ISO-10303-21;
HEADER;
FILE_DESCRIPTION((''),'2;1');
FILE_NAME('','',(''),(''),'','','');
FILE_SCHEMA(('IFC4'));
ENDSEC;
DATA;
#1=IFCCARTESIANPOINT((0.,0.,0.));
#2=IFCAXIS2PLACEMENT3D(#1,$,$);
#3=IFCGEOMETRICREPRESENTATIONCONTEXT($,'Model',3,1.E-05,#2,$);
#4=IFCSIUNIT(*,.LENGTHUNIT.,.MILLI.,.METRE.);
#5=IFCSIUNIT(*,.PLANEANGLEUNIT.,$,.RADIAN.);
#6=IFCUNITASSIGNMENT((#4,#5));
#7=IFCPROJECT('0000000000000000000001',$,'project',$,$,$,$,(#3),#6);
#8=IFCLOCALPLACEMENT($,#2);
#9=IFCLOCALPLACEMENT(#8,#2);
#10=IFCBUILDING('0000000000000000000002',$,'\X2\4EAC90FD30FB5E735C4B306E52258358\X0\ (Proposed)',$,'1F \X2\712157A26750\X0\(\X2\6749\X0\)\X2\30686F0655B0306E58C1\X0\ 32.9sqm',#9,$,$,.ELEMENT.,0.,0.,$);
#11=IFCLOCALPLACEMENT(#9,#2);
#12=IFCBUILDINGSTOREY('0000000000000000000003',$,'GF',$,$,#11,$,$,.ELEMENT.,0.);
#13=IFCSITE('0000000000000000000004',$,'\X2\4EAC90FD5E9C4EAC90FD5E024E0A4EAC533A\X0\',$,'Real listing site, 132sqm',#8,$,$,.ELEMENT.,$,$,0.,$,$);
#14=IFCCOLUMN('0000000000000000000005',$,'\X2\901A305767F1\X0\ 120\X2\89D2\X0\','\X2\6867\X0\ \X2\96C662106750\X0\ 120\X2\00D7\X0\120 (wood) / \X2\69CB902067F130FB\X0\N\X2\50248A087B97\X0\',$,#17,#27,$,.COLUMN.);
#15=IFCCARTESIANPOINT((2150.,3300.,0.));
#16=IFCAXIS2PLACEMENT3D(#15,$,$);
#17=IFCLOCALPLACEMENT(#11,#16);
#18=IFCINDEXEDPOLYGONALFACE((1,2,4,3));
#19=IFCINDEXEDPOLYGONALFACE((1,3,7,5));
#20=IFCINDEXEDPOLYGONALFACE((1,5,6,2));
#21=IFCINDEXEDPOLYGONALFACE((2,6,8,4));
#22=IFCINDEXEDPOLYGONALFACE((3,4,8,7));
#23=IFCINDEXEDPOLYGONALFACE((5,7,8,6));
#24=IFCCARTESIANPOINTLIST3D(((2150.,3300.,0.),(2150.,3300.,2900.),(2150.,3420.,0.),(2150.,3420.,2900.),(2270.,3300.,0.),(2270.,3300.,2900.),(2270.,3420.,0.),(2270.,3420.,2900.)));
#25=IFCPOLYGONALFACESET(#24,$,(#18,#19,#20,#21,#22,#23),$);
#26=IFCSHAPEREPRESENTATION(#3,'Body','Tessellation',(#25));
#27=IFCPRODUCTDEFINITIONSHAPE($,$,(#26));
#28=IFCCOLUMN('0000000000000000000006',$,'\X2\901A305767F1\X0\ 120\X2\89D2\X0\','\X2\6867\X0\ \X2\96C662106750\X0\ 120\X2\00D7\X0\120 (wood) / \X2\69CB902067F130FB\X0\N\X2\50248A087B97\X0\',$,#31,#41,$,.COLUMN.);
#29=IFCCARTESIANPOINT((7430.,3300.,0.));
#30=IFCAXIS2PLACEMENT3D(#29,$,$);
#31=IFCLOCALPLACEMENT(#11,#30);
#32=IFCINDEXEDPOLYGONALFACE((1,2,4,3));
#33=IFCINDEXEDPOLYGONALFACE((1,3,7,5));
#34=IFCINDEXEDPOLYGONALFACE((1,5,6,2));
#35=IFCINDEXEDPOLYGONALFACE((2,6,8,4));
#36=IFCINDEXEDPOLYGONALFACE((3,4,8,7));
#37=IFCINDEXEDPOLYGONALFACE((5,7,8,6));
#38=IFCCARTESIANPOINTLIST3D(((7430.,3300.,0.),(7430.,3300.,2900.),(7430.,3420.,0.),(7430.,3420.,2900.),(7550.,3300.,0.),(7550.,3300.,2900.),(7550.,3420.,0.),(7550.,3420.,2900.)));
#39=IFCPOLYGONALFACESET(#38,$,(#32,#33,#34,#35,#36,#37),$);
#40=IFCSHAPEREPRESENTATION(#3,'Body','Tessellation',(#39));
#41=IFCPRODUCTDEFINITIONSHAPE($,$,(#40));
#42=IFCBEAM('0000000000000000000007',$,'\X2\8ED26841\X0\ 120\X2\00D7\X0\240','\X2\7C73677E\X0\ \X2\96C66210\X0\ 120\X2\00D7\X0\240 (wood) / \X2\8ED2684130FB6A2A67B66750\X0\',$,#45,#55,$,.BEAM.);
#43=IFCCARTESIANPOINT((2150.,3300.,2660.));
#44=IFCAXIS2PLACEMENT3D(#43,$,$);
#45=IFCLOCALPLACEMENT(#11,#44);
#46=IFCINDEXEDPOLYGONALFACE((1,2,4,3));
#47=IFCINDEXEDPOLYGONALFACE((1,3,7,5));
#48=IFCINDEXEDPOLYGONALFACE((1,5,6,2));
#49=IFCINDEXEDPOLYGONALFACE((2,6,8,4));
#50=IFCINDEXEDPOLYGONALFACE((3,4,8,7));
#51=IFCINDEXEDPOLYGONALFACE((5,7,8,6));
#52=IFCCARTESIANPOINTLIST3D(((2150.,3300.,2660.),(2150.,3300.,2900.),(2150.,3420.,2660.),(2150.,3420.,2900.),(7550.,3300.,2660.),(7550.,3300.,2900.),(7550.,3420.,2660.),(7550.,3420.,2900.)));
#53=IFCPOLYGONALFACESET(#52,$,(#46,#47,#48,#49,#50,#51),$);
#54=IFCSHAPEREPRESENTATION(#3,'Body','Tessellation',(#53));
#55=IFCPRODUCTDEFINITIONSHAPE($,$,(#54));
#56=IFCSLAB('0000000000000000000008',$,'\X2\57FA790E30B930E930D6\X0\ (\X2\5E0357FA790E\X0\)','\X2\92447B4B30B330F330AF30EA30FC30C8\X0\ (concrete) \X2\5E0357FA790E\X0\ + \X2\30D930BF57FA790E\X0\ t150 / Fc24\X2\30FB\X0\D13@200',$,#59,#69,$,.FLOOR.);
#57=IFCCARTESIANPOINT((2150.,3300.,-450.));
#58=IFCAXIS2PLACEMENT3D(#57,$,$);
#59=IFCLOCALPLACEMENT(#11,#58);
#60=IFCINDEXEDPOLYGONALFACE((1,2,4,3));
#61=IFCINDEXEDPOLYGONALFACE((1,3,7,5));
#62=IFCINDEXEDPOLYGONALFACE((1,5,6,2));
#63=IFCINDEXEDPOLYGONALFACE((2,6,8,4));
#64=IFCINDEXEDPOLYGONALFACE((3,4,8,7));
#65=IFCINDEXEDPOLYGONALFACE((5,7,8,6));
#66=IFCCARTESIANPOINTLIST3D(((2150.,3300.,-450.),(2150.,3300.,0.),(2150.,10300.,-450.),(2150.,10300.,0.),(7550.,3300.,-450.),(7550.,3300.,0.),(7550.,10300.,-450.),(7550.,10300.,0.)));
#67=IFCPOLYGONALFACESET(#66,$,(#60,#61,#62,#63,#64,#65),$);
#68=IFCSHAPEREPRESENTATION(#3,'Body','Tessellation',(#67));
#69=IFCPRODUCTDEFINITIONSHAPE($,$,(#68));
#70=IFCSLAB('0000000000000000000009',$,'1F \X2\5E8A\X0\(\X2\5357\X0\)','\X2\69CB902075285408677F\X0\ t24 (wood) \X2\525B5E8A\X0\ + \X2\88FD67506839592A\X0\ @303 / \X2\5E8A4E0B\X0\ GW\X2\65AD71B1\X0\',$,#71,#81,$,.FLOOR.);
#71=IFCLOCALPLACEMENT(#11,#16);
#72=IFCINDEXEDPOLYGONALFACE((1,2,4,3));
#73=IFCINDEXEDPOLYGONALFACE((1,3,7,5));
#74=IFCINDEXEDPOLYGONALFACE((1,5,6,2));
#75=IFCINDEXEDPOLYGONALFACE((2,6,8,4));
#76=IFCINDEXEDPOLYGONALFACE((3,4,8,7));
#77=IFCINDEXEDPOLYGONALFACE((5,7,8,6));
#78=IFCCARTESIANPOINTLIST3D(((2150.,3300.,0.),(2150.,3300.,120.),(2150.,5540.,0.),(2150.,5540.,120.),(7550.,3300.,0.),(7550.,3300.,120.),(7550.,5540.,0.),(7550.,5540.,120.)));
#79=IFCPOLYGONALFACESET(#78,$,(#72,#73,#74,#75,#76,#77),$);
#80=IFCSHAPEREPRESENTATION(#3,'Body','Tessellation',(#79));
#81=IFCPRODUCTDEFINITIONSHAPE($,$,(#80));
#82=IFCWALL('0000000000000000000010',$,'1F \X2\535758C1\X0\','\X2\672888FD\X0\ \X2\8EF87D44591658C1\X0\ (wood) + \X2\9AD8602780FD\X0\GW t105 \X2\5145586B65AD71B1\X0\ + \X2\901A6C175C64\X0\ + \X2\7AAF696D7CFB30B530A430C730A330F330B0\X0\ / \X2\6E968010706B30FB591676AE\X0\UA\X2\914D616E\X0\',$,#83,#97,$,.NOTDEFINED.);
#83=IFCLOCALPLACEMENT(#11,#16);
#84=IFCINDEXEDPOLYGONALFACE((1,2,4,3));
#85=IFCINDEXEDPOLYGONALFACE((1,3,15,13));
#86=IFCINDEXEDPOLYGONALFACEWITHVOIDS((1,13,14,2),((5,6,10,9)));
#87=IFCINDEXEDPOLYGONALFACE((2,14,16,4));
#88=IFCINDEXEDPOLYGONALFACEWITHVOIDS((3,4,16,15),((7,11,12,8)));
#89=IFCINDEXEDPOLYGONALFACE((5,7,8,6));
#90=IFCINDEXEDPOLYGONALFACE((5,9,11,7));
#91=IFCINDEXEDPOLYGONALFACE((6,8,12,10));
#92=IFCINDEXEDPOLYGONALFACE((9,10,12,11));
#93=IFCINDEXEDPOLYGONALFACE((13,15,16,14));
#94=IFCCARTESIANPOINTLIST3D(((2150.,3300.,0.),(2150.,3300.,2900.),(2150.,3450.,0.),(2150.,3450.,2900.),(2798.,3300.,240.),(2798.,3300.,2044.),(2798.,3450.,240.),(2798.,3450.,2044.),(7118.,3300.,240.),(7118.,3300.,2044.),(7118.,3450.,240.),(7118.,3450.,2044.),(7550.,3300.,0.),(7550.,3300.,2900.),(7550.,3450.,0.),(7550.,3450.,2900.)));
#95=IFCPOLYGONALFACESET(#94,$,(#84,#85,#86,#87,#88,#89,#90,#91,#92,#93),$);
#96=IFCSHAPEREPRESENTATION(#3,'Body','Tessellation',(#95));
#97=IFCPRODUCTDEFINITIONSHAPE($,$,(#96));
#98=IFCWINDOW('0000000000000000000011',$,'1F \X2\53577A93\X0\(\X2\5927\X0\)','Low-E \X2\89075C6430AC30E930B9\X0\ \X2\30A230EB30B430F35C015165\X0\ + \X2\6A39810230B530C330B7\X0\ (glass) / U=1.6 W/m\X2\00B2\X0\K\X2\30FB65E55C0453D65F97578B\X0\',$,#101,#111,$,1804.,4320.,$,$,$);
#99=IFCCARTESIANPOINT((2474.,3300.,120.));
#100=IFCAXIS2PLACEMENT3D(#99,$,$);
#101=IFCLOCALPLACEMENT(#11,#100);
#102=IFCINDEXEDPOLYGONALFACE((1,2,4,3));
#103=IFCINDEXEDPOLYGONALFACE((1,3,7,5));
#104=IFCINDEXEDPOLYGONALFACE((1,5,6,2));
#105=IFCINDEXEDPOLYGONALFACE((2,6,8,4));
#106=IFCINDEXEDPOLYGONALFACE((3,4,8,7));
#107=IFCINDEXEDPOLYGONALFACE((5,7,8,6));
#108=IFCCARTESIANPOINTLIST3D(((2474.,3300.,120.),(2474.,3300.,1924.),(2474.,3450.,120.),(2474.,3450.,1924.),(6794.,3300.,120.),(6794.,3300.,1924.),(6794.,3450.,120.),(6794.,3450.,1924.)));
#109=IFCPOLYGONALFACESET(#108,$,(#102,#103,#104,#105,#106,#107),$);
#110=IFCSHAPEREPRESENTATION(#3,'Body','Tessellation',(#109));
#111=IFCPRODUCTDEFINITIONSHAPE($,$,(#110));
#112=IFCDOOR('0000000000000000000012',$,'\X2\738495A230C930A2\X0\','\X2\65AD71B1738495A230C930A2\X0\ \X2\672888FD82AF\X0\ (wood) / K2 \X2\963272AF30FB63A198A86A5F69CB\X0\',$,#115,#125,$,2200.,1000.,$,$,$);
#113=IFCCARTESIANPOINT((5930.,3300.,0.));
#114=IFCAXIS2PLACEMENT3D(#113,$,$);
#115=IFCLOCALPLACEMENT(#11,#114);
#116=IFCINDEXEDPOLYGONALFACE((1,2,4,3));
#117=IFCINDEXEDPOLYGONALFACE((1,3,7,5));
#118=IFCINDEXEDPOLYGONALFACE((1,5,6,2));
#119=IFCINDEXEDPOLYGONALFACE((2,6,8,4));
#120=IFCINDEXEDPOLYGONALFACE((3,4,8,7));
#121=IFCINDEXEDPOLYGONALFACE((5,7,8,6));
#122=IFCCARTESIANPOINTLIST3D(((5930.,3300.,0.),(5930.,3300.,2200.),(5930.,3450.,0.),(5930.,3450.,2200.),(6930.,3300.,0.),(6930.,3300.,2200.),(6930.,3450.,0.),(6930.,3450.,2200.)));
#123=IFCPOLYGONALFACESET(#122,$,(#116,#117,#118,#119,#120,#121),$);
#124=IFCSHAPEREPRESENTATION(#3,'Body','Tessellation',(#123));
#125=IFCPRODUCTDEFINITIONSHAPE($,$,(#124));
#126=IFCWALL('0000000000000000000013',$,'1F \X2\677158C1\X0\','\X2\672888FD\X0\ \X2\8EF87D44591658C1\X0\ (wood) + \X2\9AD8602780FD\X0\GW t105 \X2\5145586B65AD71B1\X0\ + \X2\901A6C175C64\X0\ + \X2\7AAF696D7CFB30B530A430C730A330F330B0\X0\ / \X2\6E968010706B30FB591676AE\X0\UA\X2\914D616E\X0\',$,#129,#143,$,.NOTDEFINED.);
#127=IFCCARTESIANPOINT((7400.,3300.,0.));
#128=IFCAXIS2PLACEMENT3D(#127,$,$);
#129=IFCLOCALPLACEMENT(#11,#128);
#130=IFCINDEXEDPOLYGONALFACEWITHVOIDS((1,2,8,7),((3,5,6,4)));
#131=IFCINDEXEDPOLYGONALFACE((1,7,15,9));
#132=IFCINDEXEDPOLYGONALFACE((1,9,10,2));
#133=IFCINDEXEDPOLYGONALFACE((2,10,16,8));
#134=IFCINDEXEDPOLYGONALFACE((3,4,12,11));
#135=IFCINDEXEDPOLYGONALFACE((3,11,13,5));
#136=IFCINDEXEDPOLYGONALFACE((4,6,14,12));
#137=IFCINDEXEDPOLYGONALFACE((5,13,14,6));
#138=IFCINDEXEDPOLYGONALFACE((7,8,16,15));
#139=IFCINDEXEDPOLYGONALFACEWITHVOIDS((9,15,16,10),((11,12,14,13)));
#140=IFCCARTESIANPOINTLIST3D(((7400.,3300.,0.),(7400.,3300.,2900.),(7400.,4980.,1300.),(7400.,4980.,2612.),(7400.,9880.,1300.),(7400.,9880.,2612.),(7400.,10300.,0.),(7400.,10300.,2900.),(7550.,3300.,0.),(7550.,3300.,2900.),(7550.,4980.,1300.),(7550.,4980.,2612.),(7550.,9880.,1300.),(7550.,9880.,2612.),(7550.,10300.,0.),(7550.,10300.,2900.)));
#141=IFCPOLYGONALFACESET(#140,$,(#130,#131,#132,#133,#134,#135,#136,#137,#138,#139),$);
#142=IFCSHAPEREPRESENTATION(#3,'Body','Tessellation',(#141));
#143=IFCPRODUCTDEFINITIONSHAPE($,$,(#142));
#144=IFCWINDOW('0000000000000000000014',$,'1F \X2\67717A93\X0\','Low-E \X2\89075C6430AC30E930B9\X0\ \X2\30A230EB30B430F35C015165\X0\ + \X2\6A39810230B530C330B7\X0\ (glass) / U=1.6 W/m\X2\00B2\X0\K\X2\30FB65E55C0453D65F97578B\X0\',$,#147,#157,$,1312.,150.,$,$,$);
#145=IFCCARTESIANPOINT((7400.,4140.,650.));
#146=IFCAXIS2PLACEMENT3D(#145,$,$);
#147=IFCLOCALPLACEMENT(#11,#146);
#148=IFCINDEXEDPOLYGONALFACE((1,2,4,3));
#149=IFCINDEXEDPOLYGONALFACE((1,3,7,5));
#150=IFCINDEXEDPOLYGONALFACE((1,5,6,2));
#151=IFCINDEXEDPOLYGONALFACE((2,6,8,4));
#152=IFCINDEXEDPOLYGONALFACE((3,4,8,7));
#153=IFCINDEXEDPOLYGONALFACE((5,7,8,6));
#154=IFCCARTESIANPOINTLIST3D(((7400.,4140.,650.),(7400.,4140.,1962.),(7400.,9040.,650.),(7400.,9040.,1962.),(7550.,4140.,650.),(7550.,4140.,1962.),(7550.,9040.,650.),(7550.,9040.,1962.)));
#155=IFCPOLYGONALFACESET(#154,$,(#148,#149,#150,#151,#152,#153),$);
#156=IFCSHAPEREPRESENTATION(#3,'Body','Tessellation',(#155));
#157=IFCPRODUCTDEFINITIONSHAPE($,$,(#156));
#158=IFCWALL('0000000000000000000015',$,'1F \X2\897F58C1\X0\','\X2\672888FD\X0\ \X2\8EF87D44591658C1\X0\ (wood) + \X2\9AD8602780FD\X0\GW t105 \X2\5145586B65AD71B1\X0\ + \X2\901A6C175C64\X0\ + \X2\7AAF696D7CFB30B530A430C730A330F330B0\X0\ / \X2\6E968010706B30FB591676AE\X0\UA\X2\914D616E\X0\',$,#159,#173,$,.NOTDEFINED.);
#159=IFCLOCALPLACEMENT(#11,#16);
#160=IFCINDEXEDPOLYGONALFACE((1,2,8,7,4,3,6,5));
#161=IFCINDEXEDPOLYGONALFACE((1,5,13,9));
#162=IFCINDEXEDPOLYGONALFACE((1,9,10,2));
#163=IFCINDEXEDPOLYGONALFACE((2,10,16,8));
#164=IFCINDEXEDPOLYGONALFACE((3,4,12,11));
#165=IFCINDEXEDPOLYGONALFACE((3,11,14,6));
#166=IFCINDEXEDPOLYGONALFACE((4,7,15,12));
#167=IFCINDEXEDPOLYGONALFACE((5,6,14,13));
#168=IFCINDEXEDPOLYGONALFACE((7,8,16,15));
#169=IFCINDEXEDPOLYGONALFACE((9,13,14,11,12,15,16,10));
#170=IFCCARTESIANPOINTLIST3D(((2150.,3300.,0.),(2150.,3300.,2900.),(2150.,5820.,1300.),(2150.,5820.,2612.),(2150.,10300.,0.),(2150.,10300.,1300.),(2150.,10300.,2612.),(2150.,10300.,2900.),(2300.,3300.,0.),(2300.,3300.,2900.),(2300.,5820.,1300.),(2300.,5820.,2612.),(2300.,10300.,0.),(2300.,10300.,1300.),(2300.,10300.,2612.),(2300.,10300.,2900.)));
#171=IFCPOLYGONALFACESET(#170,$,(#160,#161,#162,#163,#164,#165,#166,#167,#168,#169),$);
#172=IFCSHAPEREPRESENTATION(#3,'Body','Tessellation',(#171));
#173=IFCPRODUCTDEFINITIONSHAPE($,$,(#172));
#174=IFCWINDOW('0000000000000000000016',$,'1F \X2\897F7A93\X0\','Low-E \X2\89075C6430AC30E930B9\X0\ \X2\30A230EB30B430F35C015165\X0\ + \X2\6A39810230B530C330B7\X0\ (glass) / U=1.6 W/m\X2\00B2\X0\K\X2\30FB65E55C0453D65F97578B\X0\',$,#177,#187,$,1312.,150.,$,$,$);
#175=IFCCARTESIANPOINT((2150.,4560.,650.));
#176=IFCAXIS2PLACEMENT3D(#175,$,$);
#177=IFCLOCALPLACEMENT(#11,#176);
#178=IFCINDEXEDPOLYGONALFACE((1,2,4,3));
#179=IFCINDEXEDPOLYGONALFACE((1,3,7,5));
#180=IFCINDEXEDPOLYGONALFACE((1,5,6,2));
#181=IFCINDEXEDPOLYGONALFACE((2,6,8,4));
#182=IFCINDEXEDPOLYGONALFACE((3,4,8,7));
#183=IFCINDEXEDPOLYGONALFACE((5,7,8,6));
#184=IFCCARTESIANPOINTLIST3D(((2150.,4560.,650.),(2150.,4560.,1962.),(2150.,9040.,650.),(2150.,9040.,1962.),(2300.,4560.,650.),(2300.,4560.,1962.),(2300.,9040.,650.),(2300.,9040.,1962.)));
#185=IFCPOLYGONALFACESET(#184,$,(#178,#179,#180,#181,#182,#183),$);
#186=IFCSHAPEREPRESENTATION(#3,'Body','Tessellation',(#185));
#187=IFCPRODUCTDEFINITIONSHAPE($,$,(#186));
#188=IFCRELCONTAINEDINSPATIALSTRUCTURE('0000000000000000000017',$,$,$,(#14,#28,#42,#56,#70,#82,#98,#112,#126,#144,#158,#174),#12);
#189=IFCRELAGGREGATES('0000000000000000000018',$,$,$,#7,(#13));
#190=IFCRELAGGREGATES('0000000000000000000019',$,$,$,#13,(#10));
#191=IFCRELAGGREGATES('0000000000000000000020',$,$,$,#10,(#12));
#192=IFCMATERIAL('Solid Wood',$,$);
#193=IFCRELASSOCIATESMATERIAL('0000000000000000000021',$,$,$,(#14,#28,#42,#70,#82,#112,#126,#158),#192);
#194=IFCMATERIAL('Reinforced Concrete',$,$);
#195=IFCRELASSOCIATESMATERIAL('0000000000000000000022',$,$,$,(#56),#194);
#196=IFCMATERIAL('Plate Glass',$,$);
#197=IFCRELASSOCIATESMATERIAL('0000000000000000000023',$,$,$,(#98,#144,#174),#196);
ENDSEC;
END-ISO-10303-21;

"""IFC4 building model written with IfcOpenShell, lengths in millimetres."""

from ifc_helpers import new_model, si_unit, frame, frame_2d, origin, place, context, project, spatial, rectangle, extrude, material, element, fill, save


model = new_model("IFC4")

# Units and contexts
model_context = context("Model", 3, precision=1e-05, world=origin())
ifc_project = project(units=[si_unit("LENGTHUNIT", "METRE", prefix="MILLI"), si_unit("PLANEANGLEUNIT", "RADIAN")], contexts=[model_context])

# Site, building, storey
site_placement = place(None, origin())
site = spatial("IfcSite", under=ifc_project, at=site_placement, Name="京都府京都市上京区", ObjectType="Real listing site, 132sqm", CompositionType="ELEMENT", RefElevation=0.0)
building_placement = place(site_placement, origin())
building = spatial("IfcBuilding", under=site, at=building_placement, Name="京都・平屋の別荘 (Proposed)", ObjectType="1F 無垢材(杉)と漆喰の壁 32.9sqm", CompositionType="ELEMENT", ElevationOfRefHeight=0.0, ElevationOfTerrain=0.0)
storey_placement = place(building_placement, origin())
storey = spatial("IfcBuildingStorey", under=building, at=storey_placement, Name="GF", CompositionType="ELEMENT", Elevation=0.0)

# Columns
ifc_material_1 = material(Name="Solid Wood")
column_1_placement = place(storey_placement, frame((2150.0, 3300.0, 0.0)))
element("IfcColumn", 1, at=column_1_placement, inside=storey, material=ifc_material_1, Name="通し柱 120角", Description="桧 集成材 120×120 (wood) / 構造柱・N値計算", PredefinedType="COLUMN", context=model_context, shape_type="SweptSolid", body=[
    extrude(rectangle(XDim=120.0, YDim=120.0, at=frame_2d((60.0, 60.0))), frame((2150.0, 3300.0, 0.0)), (0.0, 0.0, 1.0), 2900.0),
])
column_2_placement = place(storey_placement, frame((7430.0, 3300.0, 0.0)))
element("IfcColumn", 2, at=column_2_placement, inside=storey, material=ifc_material_1, Name="通し柱 120角", Description="桧 集成材 120×120 (wood) / 構造柱・N値計算", PredefinedType="COLUMN", context=model_context, shape_type="SweptSolid", body=[
    extrude(rectangle(XDim=120.0, YDim=120.0, at=frame_2d((60.0, 60.0))), frame((7430.0, 3300.0, 0.0)), (0.0, 0.0, 1.0), 2900.0),
])

# Beam
beam_1_placement = place(storey_placement, frame((2150.0, 3300.0, 2660.0)))
element("IfcBeam", 3, at=beam_1_placement, inside=storey, material=ifc_material_1, Name="軒桁 120×240", Description="米松 集成 120×240 (wood) / 軒桁・横架材", PredefinedType="BEAM", context=model_context, shape_type="SweptSolid", body=[
    extrude(rectangle(XDim=5400.0, YDim=120.0, at=frame_2d((2700.0, 60.0))), frame((2150.0, 3300.0, 2660.0)), (0.0, 0.0, 1.0), 240.0),
])

# Slabs
ifc_material_2 = material(Name="Reinforced Concrete")
slab_1_placement = place(storey_placement, frame((2150.0, 3300.0, -450.0)))
element("IfcSlab", 4, at=slab_1_placement, inside=storey, material=ifc_material_2, Name="基礎スラブ (布基礎)", Description="鉄筋コンクリート (concrete) 布基礎 + ベタ基礎 t150 / Fc24・D13@200", PredefinedType="FLOOR", context=model_context, shape_type="SweptSolid", body=[
    extrude(rectangle(XDim=5400.0, YDim=7000.0, at=frame_2d((2700.0, 3500.0))), frame((2150.0, 3300.0, -450.0)), (0.0, 0.0, 1.0), 450.0),
])
slab_2_placement = place(storey_placement, frame((2150.0, 3300.0, 0.0)))
element("IfcSlab", 5, at=slab_2_placement, inside=storey, material=ifc_material_1, Name="1F 床(南)", Description="構造用合板 t24 (wood) 剛床 + 製材根太 @303 / 床下 GW断熱", PredefinedType="FLOOR", context=model_context, shape_type="SweptSolid", body=[
    extrude(rectangle(XDim=5400.0, YDim=2240.0, at=frame_2d((2700.0, 1120.0))), frame((2150.0, 3300.0, 0.0)), (0.0, 0.0, 1.0), 120.0),
])

# Wall, openings, window, door
wall_1_placement = place(storey_placement, frame((2150.0, 3300.0, 0.0)))
wall_1 = element("IfcWall", 6, at=wall_1_placement, inside=storey, material=ifc_material_1, Name="1F 南壁", Description="木製 軸組外壁 (wood) + 高性能GW t105 充填断熱 + 通気層 + 窯業系サイディング / 準耐火・外皮UA配慮", PredefinedType="NOTDEFINED", context=model_context, shape_type="SweptSolid", body=[
    extrude(rectangle(XDim=5400.0, YDim=150.0, at=frame_2d((2700.0, 75.0))), frame((2150.0, 3300.0, 0.0)), (0.0, 0.0, 1.0), 2900.0),
])
opening_1_placement = place(storey_placement, frame((2474.0, 3300.0, 120.0)))
opening_1 = element("IfcOpeningElement", 7, at=opening_1_placement, cuts=wall_1, PredefinedType="NOTDEFINED", context=model_context, shape_type="SweptSolid", body=[
    extrude(rectangle(XDim=4320.0, YDim=150.0, at=frame_2d((2160.0, 75.0))), frame((2474.0, 3300.0, 120.0)), (0.0, 0.0, 1.0), 1804.0),
])
opening_2_placement = place(storey_placement, frame((5930.0, 3300.0, 0.0)))
opening_2 = element("IfcOpeningElement", 8, at=opening_2_placement, cuts=wall_1, PredefinedType="NOTDEFINED", context=model_context, shape_type="SweptSolid", body=[
    extrude(rectangle(XDim=1000.0, YDim=150.0, at=frame_2d((500.0, 75.0))), frame((5930.0, 3300.0, 0.0)), (0.0, 0.0, 1.0), 2200.0),
])
ifc_material_3 = material(Name="Plate Glass")
window_1_placement = place(storey_placement, frame((2474.0, 3300.0, 120.0)))
window_1 = element("IfcWindow", 9, at=window_1_placement, inside=storey, material=ifc_material_3, Name="1F 南窓(大)", Description="Low-E 複層ガラス アルゴン封入 + 樹脂サッシ (glass) / U=1.6 W/m²K・日射取得型", OverallHeight=1804.0, OverallWidth=4320.0, context=model_context, shape_type="SweptSolid", body=[
    extrude(rectangle(XDim=4320.0, YDim=150.0, at=frame_2d((2160.0, 75.0))), frame((2474.0, 3300.0, 120.0)), (0.0, 0.0, 1.0), 1804.0),
])
fill(opening_1, window_1)
door_placement = place(storey_placement, frame((5930.0, 3300.0, 0.0)))
door = element("IfcDoor", 10, at=door_placement, inside=storey, material=ifc_material_1, Name="玄関ドア", Description="断熱玄関ドア 木製芯 (wood) / K2 防犯・採風機構", OverallHeight=2200.0, OverallWidth=1000.0, context=model_context, shape_type="SweptSolid", body=[
    extrude(rectangle(XDim=1000.0, YDim=150.0, at=frame_2d((500.0, 75.0))), frame((5930.0, 3300.0, 0.0)), (0.0, 0.0, 1.0), 2200.0),
])
fill(opening_2, door)

# Walls, openings, windows
wall_2_placement = place(storey_placement, frame((7400.0, 3300.0, 0.0)))
wall_2 = element("IfcWall", 11, at=wall_2_placement, inside=storey, material=ifc_material_1, Name="1F 東壁", Description="木製 軸組外壁 (wood) + 高性能GW t105 充填断熱 + 通気層 + 窯業系サイディング / 準耐火・外皮UA配慮", PredefinedType="NOTDEFINED", context=model_context, shape_type="SweptSolid", body=[
    extrude(rectangle(XDim=150.0, YDim=7000.0, at=frame_2d((75.0, 3500.0))), frame((7400.0, 3300.0, 0.0)), (0.0, 0.0, 1.0), 2900.0),
])
opening_3_placement = place(storey_placement, frame((7400.0, 4140.0, 650.0)))
opening_3 = element("IfcOpeningElement", 12, at=opening_3_placement, cuts=wall_2, PredefinedType="NOTDEFINED", context=model_context, shape_type="SweptSolid", body=[
    extrude(rectangle(XDim=150.0, YDim=4900.0, at=frame_2d((75.0, 2450.0))), frame((7400.0, 4140.0, 650.0)), (0.0, 0.0, 1.0), 1312.0),
])
window_2_placement = place(storey_placement, frame((7400.0, 4140.0, 650.0)))
window_2 = element("IfcWindow", 13, at=window_2_placement, inside=storey, material=ifc_material_3, Name="1F 東窓", Description="Low-E 複層ガラス アルゴン封入 + 樹脂サッシ (glass) / U=1.6 W/m²K・日射取得型", OverallHeight=1312.0, OverallWidth=150.0, context=model_context, shape_type="SweptSolid", body=[
    extrude(rectangle(XDim=150.0, YDim=4900.0, at=frame_2d((75.0, 2450.0))), frame((7400.0, 4140.0, 650.0)), (0.0, 0.0, 1.0), 1312.0),
])
fill(opening_3, window_2)
wall_3_placement = place(storey_placement, frame((2150.0, 3300.0, 0.0)))
wall_3 = element("IfcWall", 14, at=wall_3_placement, inside=storey, material=ifc_material_1, Name="1F 西壁", Description="木製 軸組外壁 (wood) + 高性能GW t105 充填断熱 + 通気層 + 窯業系サイディング / 準耐火・外皮UA配慮", PredefinedType="NOTDEFINED", context=model_context, shape_type="SweptSolid", body=[
    extrude(rectangle(XDim=150.0, YDim=7000.0, at=frame_2d((75.0, 3500.0))), frame((2150.0, 3300.0, 0.0)), (0.0, 0.0, 1.0), 2900.0),
])
opening_4_placement = place(storey_placement, frame((2150.0, 4560.0, 650.0)))
opening_4 = element("IfcOpeningElement", 15, at=opening_4_placement, cuts=wall_3, PredefinedType="NOTDEFINED", context=model_context, shape_type="SweptSolid", body=[
    extrude(rectangle(XDim=150.0, YDim=4480.0, at=frame_2d((75.0, 2240.0))), frame((2150.0, 4560.0, 650.0)), (0.0, 0.0, 1.0), 1312.0),
])
window_3_placement = place(storey_placement, frame((2150.0, 4560.0, 650.0)))
window_3 = element("IfcWindow", 16, at=window_3_placement, inside=storey, material=ifc_material_3, Name="1F 西窓", Description="Low-E 複層ガラス アルゴン封入 + 樹脂サッシ (glass) / U=1.6 W/m²K・日射取得型", OverallHeight=1312.0, OverallWidth=150.0, context=model_context, shape_type="SweptSolid", body=[
    extrude(rectangle(XDim=150.0, YDim=4480.0, at=frame_2d((75.0, 2240.0))), frame((2150.0, 4560.0, 650.0)), (0.0, 0.0, 1.0), 1312.0),
])
fill(opening_4, window_3)

save(model, "model.ifc")
